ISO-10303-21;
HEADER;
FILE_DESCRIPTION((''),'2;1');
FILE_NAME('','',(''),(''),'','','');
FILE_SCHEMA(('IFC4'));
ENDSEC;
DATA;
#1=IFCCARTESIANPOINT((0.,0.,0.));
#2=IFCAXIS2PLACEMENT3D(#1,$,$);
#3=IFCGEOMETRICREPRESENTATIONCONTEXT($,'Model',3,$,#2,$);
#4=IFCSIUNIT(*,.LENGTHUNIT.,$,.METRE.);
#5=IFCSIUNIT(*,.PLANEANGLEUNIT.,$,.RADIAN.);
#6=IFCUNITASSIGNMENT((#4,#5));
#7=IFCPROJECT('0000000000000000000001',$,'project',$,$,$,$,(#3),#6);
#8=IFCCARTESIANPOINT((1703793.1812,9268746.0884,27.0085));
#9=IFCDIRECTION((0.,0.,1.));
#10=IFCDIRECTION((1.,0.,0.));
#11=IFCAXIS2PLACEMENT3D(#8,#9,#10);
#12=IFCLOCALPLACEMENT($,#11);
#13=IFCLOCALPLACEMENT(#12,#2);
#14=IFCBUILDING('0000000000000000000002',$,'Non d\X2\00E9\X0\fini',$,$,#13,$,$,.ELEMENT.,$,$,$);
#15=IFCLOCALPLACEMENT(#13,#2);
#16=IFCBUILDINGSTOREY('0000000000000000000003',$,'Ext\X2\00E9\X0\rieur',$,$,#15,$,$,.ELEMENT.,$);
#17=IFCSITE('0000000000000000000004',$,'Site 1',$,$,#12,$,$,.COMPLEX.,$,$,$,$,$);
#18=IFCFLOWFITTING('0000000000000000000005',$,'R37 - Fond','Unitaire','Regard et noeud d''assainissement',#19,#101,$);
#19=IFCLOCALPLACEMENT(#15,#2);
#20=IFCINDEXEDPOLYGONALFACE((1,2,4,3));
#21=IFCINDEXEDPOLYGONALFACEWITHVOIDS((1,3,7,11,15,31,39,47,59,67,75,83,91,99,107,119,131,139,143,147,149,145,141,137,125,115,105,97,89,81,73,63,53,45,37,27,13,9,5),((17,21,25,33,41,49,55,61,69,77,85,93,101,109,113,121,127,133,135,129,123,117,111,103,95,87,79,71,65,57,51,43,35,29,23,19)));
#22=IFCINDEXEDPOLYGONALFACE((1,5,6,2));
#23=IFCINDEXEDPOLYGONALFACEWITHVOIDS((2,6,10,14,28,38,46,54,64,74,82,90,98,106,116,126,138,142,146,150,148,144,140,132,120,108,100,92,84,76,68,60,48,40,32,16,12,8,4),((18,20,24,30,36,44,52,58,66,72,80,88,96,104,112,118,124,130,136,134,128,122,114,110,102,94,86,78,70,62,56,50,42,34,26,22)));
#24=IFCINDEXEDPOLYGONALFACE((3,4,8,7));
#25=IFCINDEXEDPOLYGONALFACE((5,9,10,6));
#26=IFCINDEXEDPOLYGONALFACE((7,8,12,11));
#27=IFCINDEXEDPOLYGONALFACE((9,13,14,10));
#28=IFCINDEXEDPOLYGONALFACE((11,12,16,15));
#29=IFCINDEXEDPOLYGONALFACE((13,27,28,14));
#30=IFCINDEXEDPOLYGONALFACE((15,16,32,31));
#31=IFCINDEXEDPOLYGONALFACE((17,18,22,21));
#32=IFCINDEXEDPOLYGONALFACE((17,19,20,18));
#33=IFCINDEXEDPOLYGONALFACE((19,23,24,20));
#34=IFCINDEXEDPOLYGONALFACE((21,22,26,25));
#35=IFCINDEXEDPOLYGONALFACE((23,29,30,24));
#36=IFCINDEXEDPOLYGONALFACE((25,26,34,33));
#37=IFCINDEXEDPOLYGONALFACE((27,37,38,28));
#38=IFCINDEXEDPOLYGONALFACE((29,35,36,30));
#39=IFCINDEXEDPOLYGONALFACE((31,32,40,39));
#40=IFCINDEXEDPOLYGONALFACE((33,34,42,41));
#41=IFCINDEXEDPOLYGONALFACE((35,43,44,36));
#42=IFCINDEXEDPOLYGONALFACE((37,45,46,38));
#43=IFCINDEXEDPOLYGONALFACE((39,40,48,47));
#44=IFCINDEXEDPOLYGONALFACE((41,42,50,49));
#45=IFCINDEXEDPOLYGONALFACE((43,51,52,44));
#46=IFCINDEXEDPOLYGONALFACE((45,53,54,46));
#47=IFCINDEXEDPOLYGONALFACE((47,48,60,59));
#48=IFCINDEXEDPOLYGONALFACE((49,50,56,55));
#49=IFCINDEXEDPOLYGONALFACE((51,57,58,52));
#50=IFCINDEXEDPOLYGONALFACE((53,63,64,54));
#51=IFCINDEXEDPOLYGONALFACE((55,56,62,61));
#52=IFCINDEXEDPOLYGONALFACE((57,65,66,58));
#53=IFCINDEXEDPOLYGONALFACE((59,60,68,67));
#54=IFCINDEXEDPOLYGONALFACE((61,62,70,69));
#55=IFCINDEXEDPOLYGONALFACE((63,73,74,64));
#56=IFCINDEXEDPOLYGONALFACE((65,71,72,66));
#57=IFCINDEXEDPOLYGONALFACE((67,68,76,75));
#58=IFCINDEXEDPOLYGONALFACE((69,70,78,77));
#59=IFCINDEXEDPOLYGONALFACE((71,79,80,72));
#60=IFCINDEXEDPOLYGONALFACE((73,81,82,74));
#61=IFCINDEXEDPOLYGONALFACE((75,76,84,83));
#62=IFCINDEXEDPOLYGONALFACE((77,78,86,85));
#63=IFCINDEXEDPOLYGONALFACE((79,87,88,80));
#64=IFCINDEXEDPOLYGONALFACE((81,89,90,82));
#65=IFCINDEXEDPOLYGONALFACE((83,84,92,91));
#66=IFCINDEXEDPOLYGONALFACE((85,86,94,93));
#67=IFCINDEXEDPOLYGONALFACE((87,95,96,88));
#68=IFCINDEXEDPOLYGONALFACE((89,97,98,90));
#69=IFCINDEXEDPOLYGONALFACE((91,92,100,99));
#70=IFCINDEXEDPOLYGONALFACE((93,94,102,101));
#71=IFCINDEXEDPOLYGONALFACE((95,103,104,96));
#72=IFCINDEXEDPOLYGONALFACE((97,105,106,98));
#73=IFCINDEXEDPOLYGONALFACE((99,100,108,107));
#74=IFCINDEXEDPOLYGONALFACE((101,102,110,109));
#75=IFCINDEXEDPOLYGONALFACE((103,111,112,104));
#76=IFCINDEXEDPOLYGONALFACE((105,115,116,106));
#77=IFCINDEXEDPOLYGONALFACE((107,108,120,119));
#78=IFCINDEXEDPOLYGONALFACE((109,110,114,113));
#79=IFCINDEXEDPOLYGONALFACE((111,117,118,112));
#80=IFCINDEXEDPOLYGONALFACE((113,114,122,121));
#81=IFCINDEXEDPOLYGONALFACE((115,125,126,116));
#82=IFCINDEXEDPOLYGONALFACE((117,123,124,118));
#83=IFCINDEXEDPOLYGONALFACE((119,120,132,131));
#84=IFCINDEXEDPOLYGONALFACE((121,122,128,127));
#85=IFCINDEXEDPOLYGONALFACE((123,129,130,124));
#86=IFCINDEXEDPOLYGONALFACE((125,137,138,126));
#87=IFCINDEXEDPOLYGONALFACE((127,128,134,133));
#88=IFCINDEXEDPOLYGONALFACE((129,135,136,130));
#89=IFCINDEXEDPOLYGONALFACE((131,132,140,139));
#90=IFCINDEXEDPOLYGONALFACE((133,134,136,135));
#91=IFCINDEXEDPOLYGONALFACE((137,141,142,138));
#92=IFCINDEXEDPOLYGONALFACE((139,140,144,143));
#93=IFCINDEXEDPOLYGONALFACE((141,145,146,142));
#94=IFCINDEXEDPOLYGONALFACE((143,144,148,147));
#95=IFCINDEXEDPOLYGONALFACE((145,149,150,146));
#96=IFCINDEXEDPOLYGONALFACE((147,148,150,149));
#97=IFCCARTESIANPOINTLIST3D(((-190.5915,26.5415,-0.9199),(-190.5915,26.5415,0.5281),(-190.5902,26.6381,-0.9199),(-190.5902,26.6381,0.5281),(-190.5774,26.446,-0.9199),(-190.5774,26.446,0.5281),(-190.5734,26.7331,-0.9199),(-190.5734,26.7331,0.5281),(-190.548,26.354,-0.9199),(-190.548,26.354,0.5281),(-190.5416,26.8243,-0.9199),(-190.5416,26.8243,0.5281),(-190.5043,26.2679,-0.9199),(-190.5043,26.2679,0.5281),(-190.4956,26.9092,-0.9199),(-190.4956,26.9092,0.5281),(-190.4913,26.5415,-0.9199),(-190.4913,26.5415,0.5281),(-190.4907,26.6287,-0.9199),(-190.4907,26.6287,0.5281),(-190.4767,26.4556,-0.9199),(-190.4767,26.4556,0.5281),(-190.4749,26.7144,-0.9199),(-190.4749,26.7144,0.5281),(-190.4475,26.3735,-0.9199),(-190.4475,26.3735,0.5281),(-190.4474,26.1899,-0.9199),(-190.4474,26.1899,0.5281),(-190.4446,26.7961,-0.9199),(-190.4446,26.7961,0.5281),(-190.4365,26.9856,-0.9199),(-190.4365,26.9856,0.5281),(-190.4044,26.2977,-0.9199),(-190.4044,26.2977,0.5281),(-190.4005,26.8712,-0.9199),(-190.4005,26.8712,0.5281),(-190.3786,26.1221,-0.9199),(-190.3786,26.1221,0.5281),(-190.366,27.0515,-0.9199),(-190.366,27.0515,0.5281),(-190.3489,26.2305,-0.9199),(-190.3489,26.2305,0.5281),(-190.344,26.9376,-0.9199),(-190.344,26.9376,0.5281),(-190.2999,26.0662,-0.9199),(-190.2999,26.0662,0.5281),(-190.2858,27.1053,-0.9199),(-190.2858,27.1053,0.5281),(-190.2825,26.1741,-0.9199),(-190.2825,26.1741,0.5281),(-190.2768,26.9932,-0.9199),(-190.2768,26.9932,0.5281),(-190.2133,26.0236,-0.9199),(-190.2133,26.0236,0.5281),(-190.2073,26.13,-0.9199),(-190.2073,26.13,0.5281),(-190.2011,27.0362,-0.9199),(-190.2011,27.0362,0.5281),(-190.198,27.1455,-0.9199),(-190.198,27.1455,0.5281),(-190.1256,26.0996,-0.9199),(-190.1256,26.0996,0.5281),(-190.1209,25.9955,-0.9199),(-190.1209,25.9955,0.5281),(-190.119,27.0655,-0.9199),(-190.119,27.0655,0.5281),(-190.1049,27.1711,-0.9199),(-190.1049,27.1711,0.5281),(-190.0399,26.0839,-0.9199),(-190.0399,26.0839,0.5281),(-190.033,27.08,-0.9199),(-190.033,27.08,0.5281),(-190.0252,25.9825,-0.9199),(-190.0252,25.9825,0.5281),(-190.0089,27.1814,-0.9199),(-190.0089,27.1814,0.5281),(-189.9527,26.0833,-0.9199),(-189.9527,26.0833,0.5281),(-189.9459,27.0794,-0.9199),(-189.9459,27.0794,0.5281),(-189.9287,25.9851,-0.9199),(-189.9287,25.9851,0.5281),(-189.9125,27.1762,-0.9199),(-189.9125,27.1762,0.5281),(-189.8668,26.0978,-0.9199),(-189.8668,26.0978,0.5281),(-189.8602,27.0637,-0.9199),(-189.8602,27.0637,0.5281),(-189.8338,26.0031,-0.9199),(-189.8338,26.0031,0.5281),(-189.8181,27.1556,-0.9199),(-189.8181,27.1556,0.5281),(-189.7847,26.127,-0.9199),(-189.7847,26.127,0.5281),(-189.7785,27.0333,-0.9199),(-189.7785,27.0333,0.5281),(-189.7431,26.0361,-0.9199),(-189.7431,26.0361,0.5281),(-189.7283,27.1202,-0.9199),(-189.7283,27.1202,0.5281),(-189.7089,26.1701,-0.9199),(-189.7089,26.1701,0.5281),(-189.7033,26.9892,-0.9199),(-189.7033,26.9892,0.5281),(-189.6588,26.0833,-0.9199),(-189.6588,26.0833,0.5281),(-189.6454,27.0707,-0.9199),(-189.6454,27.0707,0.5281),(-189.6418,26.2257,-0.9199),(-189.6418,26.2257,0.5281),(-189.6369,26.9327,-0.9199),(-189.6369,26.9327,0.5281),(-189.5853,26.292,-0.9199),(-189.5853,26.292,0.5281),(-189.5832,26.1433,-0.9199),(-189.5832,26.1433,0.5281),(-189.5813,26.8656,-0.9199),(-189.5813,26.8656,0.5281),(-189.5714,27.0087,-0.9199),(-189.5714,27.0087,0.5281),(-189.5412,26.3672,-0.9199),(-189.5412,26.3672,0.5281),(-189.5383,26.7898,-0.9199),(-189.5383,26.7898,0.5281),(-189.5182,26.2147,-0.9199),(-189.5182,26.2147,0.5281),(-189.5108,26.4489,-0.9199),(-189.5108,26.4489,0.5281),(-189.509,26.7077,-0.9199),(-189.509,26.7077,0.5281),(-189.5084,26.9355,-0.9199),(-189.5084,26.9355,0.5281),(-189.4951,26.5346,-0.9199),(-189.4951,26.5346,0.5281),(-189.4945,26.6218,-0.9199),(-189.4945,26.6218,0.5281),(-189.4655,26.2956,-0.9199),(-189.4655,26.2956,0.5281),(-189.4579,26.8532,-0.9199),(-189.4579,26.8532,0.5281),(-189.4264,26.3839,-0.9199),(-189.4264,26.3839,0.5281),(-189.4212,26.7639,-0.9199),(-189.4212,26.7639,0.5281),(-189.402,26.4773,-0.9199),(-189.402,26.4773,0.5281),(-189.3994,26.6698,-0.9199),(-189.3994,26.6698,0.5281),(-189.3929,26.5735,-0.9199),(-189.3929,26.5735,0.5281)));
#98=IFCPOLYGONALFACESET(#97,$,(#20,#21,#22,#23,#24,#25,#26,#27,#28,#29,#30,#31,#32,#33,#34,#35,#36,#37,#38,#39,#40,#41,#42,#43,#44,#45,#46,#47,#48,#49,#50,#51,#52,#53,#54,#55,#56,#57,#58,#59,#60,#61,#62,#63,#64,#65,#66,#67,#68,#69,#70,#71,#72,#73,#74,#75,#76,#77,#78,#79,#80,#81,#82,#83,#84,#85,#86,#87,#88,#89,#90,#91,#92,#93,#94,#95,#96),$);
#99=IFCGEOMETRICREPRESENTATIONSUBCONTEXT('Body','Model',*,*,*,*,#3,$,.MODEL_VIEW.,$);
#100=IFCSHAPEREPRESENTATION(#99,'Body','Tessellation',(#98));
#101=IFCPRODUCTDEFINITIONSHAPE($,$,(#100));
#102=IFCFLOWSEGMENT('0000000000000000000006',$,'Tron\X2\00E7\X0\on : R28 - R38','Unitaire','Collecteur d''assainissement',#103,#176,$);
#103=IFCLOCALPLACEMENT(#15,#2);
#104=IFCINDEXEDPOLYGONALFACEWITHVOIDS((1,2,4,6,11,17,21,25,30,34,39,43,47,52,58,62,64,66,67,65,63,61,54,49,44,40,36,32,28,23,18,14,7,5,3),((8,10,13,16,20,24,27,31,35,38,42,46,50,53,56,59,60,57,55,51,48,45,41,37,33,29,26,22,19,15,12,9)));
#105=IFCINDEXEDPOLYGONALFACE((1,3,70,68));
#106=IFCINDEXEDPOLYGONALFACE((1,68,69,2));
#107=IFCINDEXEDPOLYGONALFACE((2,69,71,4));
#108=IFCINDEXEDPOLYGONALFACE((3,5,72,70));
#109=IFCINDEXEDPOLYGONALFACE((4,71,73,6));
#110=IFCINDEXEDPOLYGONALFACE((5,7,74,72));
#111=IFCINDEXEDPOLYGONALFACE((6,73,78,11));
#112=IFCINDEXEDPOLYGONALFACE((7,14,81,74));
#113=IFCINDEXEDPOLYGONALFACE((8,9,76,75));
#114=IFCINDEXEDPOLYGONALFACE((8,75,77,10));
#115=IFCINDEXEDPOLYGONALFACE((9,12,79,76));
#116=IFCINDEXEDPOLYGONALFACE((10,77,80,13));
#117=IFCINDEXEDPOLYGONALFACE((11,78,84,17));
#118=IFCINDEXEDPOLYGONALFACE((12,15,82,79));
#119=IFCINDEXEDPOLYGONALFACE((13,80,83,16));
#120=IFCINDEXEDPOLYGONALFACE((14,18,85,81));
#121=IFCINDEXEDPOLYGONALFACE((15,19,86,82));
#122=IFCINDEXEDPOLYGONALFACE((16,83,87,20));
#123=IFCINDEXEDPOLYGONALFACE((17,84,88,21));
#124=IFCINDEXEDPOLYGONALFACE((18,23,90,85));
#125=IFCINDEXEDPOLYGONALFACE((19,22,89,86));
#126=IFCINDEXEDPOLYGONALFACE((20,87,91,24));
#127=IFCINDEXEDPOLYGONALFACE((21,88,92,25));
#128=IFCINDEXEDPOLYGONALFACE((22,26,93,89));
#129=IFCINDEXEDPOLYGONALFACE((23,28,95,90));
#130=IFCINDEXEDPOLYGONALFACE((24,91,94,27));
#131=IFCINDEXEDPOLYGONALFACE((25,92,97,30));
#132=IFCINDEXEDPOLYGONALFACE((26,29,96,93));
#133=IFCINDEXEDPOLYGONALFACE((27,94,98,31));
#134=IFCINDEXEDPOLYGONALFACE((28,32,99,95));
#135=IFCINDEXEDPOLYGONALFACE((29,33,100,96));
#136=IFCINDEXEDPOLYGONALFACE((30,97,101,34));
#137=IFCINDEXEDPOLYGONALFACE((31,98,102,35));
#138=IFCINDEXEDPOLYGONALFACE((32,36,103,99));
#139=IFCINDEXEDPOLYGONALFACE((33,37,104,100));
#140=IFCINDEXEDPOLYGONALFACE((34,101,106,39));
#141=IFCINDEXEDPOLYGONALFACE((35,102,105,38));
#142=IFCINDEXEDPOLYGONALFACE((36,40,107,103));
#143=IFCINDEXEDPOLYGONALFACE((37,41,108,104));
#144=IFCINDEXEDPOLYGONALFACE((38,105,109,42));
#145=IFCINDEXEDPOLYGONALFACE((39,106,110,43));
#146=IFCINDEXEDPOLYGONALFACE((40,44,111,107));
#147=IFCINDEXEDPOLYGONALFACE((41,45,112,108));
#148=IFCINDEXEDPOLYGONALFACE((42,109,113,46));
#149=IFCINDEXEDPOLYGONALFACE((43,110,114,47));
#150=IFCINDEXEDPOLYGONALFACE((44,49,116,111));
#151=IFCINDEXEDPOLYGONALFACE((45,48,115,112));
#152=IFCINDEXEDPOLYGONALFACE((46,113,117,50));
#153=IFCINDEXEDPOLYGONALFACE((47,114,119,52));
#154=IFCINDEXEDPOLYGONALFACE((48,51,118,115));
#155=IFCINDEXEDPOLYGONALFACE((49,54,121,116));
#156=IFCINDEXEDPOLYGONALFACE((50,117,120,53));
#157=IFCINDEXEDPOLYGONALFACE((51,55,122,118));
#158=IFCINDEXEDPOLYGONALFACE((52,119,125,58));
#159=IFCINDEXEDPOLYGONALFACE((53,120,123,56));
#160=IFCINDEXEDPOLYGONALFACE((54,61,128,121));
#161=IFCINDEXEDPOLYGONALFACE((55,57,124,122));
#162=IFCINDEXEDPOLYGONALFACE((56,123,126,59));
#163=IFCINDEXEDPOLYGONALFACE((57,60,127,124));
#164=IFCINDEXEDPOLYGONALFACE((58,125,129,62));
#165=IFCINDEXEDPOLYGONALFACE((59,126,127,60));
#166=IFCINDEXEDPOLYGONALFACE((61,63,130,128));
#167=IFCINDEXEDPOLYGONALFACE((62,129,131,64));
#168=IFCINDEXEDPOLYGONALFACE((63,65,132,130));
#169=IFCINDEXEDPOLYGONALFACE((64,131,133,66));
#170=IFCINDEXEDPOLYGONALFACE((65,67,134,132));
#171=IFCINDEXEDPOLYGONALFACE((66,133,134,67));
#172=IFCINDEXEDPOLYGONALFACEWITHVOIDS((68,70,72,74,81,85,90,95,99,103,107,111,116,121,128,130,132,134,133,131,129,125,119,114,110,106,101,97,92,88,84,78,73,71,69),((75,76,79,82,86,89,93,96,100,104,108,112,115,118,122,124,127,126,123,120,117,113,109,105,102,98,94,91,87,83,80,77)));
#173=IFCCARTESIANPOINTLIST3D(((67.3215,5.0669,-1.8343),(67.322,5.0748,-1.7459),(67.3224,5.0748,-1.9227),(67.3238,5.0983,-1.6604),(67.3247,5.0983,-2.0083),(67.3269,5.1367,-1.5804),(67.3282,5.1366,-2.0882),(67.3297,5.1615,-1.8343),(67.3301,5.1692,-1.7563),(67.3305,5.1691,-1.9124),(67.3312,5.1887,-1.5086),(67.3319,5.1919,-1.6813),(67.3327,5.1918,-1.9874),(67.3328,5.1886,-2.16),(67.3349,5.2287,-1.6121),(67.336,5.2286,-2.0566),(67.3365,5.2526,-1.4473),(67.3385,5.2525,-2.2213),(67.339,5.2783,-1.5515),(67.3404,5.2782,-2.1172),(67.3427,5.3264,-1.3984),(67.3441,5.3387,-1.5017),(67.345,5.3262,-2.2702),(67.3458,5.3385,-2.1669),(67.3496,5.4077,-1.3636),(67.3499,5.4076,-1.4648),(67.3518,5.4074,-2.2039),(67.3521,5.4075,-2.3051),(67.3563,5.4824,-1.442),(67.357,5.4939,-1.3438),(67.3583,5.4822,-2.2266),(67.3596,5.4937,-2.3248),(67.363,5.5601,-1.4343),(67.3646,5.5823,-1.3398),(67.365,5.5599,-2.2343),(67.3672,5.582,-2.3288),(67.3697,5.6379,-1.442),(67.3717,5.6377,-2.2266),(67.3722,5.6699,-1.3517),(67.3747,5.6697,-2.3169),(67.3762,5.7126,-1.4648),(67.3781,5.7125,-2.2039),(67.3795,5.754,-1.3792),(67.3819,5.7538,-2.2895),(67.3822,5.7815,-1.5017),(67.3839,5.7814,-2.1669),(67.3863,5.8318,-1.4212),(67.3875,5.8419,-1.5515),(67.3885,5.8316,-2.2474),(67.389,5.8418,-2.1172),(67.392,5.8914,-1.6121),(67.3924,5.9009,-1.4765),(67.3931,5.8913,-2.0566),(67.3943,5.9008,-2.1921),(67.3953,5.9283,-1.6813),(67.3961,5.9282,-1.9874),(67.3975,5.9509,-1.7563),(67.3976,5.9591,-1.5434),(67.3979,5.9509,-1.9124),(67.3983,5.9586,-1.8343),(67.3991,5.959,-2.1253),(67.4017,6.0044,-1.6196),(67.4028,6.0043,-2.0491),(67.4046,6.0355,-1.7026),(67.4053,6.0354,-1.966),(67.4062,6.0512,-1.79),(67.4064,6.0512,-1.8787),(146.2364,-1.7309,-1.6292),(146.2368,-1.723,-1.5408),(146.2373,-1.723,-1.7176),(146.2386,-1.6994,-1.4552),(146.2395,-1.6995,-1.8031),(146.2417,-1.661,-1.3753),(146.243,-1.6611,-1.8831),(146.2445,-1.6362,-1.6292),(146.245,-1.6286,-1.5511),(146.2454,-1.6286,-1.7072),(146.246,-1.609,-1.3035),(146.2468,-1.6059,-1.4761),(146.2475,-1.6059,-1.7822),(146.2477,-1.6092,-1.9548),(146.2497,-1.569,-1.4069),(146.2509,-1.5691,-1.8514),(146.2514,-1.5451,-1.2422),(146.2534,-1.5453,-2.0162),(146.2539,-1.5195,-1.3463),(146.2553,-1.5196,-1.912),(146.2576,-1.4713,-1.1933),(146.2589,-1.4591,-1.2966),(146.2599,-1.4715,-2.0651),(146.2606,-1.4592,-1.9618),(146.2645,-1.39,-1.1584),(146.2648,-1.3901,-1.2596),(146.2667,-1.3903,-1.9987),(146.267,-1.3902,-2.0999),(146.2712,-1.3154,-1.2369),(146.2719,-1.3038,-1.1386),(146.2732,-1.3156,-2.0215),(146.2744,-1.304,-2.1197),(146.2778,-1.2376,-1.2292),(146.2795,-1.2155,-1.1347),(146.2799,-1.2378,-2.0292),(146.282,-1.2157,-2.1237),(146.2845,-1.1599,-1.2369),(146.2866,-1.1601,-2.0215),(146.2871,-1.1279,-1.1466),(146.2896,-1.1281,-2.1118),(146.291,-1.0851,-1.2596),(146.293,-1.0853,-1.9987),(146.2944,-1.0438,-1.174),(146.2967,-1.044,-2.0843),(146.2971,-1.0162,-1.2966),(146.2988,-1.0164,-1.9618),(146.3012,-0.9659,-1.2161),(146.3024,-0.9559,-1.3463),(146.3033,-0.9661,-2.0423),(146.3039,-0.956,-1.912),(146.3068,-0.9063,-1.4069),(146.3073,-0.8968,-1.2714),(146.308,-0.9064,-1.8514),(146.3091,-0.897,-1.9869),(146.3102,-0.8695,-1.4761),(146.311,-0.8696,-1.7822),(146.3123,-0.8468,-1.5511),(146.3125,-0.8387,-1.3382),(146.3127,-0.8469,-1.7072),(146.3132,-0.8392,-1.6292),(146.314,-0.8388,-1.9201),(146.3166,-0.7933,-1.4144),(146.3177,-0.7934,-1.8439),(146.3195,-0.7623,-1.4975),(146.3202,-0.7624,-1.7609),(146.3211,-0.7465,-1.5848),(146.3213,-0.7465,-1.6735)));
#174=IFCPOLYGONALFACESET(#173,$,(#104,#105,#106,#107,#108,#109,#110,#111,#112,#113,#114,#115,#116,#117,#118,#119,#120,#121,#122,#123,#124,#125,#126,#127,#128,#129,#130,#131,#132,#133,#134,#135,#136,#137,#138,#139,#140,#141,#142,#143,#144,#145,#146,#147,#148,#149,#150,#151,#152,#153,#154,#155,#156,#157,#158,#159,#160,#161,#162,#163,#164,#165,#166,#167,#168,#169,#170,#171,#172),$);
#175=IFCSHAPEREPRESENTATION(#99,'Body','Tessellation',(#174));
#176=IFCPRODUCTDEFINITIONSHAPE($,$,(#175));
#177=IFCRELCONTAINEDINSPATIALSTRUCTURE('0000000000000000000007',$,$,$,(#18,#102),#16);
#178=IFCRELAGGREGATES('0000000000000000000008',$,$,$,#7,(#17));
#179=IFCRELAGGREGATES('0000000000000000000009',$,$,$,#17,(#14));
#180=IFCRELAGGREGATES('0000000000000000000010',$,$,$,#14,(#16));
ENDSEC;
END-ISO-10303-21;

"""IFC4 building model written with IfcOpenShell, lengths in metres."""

from ifc_helpers import new_model, si_unit, frame, origin, origin_2d, place, context, subcontext, project, spatial, hollow_circle, extrude, element, save


model = new_model("IFC4")

# Units and contexts
model_context = context("Model", 3, world=origin())
body_context = subcontext(model_context, "Body", "Model", "MODEL_VIEW")
ifc_project = project(units=[si_unit("LENGTHUNIT", "METRE"), si_unit("PLANEANGLEUNIT", "RADIAN")], contexts=[model_context])

# Site, building, storey
site_placement = place(None, frame((1703793.1812, 9268746.0884, 27.0085), z_axis=(0.0, 0.0, 1.0), x_axis=(1.0, 0.0, 0.0)))
site = spatial("IfcSite", under=ifc_project, at=site_placement, Name="Site 1", CompositionType="COMPLEX")
building_placement = place(site_placement, origin())
building = spatial("IfcBuilding", under=site, at=building_placement, Name="Non défini", CompositionType="ELEMENT")
storey_placement = place(building_placement, origin())
storey = spatial("IfcBuildingStorey", under=building, at=storey_placement, Name="Extérieur", CompositionType="ELEMENT")

# Flow fitting
flow_fitting_1_placement = place(storey_placement, origin())
element("IfcFlowFitting", 1, at=flow_fitting_1_placement, inside=storey, Name="R37 - Fond", Description="Unitaire", ObjectType="Regard et noeud d'assainissement", context=body_context, shape_type="SweptSolid", body=[
    extrude(hollow_circle(Radius=0.6, WallThickness=0.1, at=origin_2d()), frame((-189.9929, 26.5816, -0.9199), z_axis=(0.0, 0.0, 1.0), x_axis=(0.416361, -0.9092, 0.0)), (0.0, 0.0, 1.0), 1.448),
])

# Flow segment
flow_segment_1_placement = place(storey_placement, origin())
element("IfcFlowSegment", 2, at=flow_segment_1_placement, inside=storey, Name="Tronçon : R28 - R38", Description="Unitaire", ObjectType="Collecteur d'assainissement", context=body_context, shape_type="SweptSolid", body=[
    extrude(hollow_circle(Radius=0.495, WallThickness=0.095, at=origin_2d()), frame((146.2789, -1.2377, -1.6292), z_axis=(-0.996307, 0.085822, -0.00259), x_axis=(-0.085823, -0.99631, 0.0)), (0.0, 0.0, 1.0), 79.2074),
])

save(model, "model.ifc")
